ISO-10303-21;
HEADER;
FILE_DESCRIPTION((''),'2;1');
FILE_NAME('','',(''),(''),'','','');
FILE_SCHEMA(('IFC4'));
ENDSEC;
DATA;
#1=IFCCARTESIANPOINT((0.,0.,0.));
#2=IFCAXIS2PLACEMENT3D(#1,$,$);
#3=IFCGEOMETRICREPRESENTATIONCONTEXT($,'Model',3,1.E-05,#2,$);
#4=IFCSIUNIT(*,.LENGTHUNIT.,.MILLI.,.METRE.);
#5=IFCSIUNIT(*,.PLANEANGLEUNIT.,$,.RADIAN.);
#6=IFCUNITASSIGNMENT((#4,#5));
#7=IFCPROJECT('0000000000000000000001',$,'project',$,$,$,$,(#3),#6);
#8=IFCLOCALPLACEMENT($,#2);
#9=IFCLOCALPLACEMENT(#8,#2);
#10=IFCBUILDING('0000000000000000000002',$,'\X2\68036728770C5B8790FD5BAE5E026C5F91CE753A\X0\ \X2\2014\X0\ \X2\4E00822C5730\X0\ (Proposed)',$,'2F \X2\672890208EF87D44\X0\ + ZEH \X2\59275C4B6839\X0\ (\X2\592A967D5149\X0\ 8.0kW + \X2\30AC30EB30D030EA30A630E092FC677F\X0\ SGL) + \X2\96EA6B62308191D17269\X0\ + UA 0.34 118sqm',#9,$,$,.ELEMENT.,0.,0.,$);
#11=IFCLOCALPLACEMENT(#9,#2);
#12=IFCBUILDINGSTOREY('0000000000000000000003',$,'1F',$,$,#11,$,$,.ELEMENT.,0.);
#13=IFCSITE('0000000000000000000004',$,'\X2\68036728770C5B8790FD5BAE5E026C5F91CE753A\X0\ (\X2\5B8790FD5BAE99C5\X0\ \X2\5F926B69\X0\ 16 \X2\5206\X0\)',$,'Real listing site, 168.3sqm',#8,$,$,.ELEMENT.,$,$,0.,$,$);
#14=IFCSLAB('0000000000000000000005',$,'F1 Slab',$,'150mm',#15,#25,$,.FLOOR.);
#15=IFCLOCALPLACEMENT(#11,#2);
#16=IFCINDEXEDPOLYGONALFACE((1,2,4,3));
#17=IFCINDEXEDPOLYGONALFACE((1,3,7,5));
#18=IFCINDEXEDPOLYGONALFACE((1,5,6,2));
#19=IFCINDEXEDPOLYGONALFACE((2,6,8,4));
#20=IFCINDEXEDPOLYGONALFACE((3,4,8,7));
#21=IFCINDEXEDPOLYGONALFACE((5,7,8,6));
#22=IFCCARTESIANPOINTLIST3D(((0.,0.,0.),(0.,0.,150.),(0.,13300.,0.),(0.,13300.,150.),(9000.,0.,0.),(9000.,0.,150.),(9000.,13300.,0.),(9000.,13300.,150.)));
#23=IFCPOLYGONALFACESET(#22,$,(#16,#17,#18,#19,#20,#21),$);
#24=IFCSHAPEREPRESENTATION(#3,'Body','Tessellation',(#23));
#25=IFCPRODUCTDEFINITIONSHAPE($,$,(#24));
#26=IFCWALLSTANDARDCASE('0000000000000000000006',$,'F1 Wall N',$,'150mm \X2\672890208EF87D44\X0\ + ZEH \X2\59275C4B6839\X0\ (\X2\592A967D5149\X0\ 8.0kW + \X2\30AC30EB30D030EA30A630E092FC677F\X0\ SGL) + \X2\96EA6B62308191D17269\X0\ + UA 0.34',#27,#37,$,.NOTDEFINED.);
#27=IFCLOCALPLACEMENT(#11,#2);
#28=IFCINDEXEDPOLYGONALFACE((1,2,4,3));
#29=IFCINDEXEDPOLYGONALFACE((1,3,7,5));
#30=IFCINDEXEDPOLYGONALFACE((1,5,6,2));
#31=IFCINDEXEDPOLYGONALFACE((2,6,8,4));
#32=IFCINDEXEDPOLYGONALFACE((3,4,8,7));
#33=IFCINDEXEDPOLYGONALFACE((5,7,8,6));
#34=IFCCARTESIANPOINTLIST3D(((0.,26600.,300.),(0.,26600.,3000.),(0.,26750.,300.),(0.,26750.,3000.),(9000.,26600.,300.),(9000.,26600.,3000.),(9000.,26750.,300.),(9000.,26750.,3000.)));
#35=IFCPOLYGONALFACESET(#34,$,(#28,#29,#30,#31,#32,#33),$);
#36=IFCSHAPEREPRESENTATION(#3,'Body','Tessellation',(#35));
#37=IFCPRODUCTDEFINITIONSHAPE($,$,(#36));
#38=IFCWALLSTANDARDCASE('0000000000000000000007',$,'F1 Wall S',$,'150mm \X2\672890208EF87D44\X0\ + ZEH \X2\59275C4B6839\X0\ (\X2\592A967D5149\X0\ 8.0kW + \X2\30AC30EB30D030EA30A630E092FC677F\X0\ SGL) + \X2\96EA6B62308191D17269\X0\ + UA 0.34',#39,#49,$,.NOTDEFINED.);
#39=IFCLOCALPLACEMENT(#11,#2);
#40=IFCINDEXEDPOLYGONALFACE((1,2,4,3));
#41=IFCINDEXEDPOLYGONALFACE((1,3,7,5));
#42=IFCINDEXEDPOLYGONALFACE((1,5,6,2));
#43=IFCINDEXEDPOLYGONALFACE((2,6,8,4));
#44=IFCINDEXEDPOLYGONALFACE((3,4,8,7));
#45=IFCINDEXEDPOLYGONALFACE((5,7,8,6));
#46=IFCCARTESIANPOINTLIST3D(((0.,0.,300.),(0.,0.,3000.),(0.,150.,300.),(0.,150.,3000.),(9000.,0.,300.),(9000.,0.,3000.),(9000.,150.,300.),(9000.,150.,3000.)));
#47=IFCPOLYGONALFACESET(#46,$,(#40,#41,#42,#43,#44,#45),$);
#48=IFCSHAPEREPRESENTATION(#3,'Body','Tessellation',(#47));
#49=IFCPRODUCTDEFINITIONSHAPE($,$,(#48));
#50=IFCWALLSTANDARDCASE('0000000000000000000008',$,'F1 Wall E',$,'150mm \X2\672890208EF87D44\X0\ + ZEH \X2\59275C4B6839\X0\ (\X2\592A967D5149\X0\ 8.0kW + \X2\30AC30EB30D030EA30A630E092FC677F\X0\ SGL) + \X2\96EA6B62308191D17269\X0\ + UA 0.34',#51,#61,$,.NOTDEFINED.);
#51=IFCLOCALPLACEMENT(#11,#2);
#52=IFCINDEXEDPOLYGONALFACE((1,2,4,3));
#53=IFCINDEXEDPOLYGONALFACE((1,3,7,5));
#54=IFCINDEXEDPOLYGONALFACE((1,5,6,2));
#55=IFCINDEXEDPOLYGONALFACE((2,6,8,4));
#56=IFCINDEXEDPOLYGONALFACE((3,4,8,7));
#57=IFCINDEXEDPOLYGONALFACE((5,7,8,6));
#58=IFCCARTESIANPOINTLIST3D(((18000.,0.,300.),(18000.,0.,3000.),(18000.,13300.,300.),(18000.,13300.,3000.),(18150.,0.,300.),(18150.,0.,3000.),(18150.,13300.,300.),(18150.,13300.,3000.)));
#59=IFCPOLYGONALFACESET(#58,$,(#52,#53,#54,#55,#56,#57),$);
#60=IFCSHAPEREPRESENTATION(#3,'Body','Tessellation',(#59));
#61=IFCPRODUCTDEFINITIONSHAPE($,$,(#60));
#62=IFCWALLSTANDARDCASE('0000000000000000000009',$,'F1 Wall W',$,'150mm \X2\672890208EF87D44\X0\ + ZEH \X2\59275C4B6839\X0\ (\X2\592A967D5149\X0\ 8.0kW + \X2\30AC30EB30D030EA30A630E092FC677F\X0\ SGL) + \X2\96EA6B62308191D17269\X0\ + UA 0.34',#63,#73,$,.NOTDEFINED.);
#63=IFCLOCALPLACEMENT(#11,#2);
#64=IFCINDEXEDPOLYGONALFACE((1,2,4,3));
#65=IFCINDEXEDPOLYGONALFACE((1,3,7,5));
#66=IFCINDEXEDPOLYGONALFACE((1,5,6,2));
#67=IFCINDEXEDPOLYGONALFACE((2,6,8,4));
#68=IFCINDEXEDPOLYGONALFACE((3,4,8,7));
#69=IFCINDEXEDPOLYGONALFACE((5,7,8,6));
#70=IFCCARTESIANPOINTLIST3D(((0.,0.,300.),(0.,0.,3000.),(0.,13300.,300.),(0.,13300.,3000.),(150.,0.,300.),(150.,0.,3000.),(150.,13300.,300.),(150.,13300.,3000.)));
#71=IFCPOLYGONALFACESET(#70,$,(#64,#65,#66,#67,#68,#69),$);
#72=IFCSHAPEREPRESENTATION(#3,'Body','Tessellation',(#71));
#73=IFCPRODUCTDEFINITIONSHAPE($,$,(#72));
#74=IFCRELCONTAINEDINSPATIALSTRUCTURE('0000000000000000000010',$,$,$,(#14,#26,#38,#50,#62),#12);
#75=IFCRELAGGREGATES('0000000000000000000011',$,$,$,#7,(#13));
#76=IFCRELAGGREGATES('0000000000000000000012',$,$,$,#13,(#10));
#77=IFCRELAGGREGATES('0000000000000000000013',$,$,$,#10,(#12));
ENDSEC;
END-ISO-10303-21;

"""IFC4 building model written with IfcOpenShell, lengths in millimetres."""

from ifc_helpers import new_model, si_unit, frame, frame_2d, origin, place, context, project, spatial, rectangle, extrude, element, save


model = new_model("IFC4")

# Units and contexts
model_context = context("Model", 3, precision=1e-05, world=origin())
ifc_project = project(units=[si_unit("LENGTHUNIT", "METRE", prefix="MILLI"), si_unit("PLANEANGLEUNIT", "RADIAN")], contexts=[model_context])

# Site, building, storey
site_placement = place(None, origin())
site = spatial("IfcSite", under=ifc_project, at=site_placement, Name="栃木県宇都宮市江野町 (宇都宮駅 徒歩 16 分)", ObjectType="Real listing site, 168.3sqm", CompositionType="ELEMENT", RefElevation=0.0)
building_placement = place(site_placement, origin())
building = spatial("IfcBuilding", under=site, at=building_placement, Name="栃木県宇都宮市江野町 — 一般地 (Proposed)", ObjectType="2F 木造軸組 + ZEH 大屋根 (太陽光 8.0kW + ガルバリウム鋼板 SGL) + 雪止め金物 + UA 0.34 118sqm", CompositionType="ELEMENT", ElevationOfRefHeight=0.0, ElevationOfTerrain=0.0)
storey_placement = place(building_placement, origin())
storey = spatial("IfcBuildingStorey", under=building, at=storey_placement, Name="1F", CompositionType="ELEMENT", Elevation=0.0)

# Slab
slab_placement = place(storey_placement, origin())
element("IfcSlab", 1, at=slab_placement, inside=storey, Name="F1 Slab", ObjectType="150mm", PredefinedType="FLOOR", context=model_context, shape_type="SweptSolid", body=[
    extrude(rectangle(XDim=9000.0, YDim=13300.0, at=frame_2d((4500.0, 6650.0))), origin(), (0.0, 0.0, 1.0), 150.0),
])

# Walls
wall_1_placement = place(storey_placement, frame((0.0, 13300.0, 150.0)))
element("IfcWallStandardCase", 2, at=wall_1_placement, inside=storey, Name="F1 Wall N", ObjectType="150mm 木造軸組 + ZEH 大屋根 (太陽光 8.0kW + ガルバリウム鋼板 SGL) + 雪止め金物 + UA 0.34", PredefinedType="NOTDEFINED", context=model_context, shape_type="SweptSolid", body=[
    extrude(rectangle(XDim=9000.0, YDim=150.0, at=frame_2d((4500.0, 75.0))), frame((0.0, 13300.0, 150.0)), (0.0, 0.0, 1.0), 2700.0),
])
wall_2_placement = place(storey_placement, frame((0.0, 0.0, 150.0)))
element("IfcWallStandardCase", 3, at=wall_2_placement, inside=storey, Name="F1 Wall S", ObjectType="150mm 木造軸組 + ZEH 大屋根 (太陽光 8.0kW + ガルバリウム鋼板 SGL) + 雪止め金物 + UA 0.34", PredefinedType="NOTDEFINED", context=model_context, shape_type="SweptSolid", body=[
    extrude(rectangle(XDim=9000.0, YDim=150.0, at=frame_2d((4500.0, 75.0))), frame((0.0, 0.0, 150.0)), (0.0, 0.0, 1.0), 2700.0),
])
wall_3_placement = place(storey_placement, frame((9000.0, 0.0, 150.0)))
element("IfcWallStandardCase", 4, at=wall_3_placement, inside=storey, Name="F1 Wall E", ObjectType="150mm 木造軸組 + ZEH 大屋根 (太陽光 8.0kW + ガルバリウム鋼板 SGL) + 雪止め金物 + UA 0.34", PredefinedType="NOTDEFINED", context=model_context, shape_type="SweptSolid", body=[
    extrude(rectangle(XDim=150.0, YDim=13300.0, at=frame_2d((75.0, 6650.0))), frame((9000.0, 0.0, 150.0)), (0.0, 0.0, 1.0), 2700.0),
])
wall_4_placement = place(storey_placement, frame((0.0, 0.0, 150.0)))
element("IfcWallStandardCase", 5, at=wall_4_placement, inside=storey, Name="F1 Wall W", ObjectType="150mm 木造軸組 + ZEH 大屋根 (太陽光 8.0kW + ガルバリウム鋼板 SGL) + 雪止め金物 + UA 0.34", PredefinedType="NOTDEFINED", context=model_context, shape_type="SweptSolid", body=[
    extrude(rectangle(XDim=150.0, YDim=13300.0, at=frame_2d((75.0, 6650.0))), frame((0.0, 0.0, 150.0)), (0.0, 0.0, 1.0), 2700.0),
])

save(model, "model.ifc")
